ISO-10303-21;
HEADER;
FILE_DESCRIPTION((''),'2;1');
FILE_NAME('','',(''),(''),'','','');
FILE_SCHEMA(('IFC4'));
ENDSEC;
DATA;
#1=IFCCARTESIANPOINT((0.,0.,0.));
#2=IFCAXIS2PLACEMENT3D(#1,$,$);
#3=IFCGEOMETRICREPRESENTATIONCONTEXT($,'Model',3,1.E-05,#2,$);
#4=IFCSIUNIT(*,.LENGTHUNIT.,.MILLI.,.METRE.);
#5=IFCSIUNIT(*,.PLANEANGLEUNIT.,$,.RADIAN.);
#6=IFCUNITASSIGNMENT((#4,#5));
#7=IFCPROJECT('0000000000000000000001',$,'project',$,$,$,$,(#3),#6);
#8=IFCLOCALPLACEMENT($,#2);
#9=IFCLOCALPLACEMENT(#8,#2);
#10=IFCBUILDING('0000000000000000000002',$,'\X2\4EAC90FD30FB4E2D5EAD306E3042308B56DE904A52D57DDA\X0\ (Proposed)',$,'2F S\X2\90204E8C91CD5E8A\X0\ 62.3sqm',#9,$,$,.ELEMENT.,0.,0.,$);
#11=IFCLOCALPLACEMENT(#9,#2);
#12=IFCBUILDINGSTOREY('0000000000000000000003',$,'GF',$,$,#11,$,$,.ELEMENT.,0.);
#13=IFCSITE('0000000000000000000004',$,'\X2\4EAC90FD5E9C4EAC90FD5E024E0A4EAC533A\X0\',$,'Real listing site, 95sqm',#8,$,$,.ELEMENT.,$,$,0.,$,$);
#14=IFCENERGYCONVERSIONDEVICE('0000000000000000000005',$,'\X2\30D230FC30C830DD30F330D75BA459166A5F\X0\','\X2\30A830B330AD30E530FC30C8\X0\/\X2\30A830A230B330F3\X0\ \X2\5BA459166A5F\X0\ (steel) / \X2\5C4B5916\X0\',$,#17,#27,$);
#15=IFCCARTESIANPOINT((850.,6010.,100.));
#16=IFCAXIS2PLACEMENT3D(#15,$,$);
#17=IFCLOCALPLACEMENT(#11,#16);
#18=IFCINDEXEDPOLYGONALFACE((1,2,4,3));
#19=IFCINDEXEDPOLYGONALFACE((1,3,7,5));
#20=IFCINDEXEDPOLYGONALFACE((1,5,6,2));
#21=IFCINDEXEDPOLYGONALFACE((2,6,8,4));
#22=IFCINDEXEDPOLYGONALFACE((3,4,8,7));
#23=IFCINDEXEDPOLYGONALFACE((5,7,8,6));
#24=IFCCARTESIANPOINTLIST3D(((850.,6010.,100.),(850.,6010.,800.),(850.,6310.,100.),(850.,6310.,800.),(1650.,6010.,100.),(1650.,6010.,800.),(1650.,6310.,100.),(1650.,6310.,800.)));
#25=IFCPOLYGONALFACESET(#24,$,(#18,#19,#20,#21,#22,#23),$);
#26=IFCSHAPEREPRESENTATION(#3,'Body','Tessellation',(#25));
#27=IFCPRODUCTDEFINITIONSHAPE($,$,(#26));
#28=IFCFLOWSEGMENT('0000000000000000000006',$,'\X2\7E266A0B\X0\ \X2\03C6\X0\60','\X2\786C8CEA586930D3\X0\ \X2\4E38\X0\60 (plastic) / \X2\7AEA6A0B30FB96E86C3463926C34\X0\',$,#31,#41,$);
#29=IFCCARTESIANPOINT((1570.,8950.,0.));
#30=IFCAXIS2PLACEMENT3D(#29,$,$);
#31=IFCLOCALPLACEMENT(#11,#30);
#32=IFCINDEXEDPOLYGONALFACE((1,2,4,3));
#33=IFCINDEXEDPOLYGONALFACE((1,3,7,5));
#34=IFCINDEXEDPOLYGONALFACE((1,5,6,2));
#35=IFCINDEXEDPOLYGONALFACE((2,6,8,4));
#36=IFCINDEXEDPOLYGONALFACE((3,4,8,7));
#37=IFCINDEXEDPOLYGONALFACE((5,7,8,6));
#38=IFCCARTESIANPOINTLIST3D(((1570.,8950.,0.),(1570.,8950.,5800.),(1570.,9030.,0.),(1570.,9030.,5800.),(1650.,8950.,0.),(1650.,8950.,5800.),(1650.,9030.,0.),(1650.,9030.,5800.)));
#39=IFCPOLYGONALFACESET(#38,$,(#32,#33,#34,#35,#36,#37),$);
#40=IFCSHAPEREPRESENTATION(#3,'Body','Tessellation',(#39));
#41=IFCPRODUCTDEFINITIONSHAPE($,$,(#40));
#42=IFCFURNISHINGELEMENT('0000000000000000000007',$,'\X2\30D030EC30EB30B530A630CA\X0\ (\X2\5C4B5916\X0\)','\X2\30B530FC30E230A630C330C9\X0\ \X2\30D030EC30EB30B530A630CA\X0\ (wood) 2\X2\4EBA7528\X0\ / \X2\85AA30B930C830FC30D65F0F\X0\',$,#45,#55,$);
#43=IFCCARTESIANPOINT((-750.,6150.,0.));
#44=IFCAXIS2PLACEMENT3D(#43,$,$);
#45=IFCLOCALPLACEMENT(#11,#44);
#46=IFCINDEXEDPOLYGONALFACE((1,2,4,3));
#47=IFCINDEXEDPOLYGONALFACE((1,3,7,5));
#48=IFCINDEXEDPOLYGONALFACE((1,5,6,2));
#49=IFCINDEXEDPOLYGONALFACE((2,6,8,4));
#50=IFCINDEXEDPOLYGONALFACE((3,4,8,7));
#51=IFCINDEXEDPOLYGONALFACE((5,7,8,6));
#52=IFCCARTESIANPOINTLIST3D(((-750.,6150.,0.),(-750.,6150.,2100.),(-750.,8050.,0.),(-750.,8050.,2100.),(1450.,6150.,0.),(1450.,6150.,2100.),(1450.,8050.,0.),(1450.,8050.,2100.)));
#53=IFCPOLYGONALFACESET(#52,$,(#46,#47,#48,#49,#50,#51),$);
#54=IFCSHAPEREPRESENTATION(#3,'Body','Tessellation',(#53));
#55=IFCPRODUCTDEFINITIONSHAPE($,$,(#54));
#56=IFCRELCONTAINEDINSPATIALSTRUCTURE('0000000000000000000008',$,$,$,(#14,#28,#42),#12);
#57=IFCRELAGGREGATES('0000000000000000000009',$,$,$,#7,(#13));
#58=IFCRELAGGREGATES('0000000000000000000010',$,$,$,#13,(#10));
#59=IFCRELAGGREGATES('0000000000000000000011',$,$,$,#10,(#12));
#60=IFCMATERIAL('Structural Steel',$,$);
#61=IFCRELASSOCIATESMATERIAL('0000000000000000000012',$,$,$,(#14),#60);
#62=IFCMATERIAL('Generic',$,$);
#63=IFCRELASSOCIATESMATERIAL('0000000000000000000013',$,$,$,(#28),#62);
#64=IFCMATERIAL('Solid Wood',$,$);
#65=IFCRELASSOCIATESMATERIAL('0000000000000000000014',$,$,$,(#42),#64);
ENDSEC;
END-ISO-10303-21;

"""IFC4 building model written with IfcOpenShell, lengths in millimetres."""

from ifc_helpers import new_model, si_unit, frame, frame_2d, origin, place, context, project, spatial, rectangle, extrude, material, element, save


model = new_model("IFC4")

# Units and contexts
model_context = context("Model", 3, precision=1e-05, world=origin())
ifc_project = project(units=[si_unit("LENGTHUNIT", "METRE", prefix="MILLI"), si_unit("PLANEANGLEUNIT", "RADIAN")], contexts=[model_context])

# Site, building, storey
site_placement = place(None, origin())
site = spatial("IfcSite", under=ifc_project, at=site_placement, Name="京都府京都市上京区", ObjectType="Real listing site, 95sqm", CompositionType="ELEMENT", RefElevation=0.0)
building_placement = place(site_placement, origin())
building = spatial("IfcBuilding", under=site, at=building_placement, Name="京都・中庭のある回遊動線 (Proposed)", ObjectType="2F S造二重床 62.3sqm", CompositionType="ELEMENT", ElevationOfRefHeight=0.0, ElevationOfTerrain=0.0)
storey_placement = place(building_placement, origin())
storey = spatial("IfcBuildingStorey", under=building, at=storey_placement, Name="GF", CompositionType="ELEMENT", Elevation=0.0)

# Shared definitions
ifc_material_1 = material(Name="Solid Wood")

# Shared definitions
ifc_material_2 = material(Name="Generic")

# Energy conversion device
ifc_material_3 = material(Name="Structural Steel")
energy_conversion_device_placement = place(storey_placement, frame((850.0, 6010.0, 100.0)))
element("IfcEnergyConversionDevice", 1, at=energy_conversion_device_placement, inside=storey, material=ifc_material_3, Name="ヒートポンプ室外機", Description="エコキュート/エアコン 室外機 (steel) / 屋外", context=model_context, shape_type="SweptSolid", body=[
    extrude(rectangle(XDim=800.0, YDim=300.0, at=frame_2d((400.0, 150.0))), frame((850.0, 6010.0, 100.0)), (0.0, 0.0, 1.0), 700.0),
])

# Flow segment
flow_segment_placement = place(storey_placement, frame((1570.0, 8950.0, 0.0)))
element("IfcFlowSegment", 2, at=flow_segment_placement, inside=storey, material=ifc_material_2, Name="縦樋 φ60", Description="硬質塩ビ 丸60 (plastic) / 竪樋・雨水排水", context=model_context, shape_type="SweptSolid", body=[
    extrude(rectangle(XDim=80.0, YDim=80.0, at=frame_2d((40.0, 40.0))), frame((1570.0, 8950.0, 0.0)), (0.0, 0.0, 1.0), 5800.0),
])

# Furnishing element
furnishing_placement = place(storey_placement, frame((-750.0, 6150.0, 0.0)))
element("IfcFurnishingElement", 3, at=furnishing_placement, inside=storey, material=ifc_material_1, Name="バレルサウナ (屋外)", Description="サーモウッド バレルサウナ (wood) 2人用 / 薪ストーブ式", context=model_context, shape_type="SweptSolid", body=[
    extrude(rectangle(XDim=2200.0, YDim=1900.0, at=frame_2d((1100.0, 950.0))), frame((-750.0, 6150.0, 0.0)), (0.0, 0.0, 1.0), 2100.0),
])

save(model, "model.ifc")
